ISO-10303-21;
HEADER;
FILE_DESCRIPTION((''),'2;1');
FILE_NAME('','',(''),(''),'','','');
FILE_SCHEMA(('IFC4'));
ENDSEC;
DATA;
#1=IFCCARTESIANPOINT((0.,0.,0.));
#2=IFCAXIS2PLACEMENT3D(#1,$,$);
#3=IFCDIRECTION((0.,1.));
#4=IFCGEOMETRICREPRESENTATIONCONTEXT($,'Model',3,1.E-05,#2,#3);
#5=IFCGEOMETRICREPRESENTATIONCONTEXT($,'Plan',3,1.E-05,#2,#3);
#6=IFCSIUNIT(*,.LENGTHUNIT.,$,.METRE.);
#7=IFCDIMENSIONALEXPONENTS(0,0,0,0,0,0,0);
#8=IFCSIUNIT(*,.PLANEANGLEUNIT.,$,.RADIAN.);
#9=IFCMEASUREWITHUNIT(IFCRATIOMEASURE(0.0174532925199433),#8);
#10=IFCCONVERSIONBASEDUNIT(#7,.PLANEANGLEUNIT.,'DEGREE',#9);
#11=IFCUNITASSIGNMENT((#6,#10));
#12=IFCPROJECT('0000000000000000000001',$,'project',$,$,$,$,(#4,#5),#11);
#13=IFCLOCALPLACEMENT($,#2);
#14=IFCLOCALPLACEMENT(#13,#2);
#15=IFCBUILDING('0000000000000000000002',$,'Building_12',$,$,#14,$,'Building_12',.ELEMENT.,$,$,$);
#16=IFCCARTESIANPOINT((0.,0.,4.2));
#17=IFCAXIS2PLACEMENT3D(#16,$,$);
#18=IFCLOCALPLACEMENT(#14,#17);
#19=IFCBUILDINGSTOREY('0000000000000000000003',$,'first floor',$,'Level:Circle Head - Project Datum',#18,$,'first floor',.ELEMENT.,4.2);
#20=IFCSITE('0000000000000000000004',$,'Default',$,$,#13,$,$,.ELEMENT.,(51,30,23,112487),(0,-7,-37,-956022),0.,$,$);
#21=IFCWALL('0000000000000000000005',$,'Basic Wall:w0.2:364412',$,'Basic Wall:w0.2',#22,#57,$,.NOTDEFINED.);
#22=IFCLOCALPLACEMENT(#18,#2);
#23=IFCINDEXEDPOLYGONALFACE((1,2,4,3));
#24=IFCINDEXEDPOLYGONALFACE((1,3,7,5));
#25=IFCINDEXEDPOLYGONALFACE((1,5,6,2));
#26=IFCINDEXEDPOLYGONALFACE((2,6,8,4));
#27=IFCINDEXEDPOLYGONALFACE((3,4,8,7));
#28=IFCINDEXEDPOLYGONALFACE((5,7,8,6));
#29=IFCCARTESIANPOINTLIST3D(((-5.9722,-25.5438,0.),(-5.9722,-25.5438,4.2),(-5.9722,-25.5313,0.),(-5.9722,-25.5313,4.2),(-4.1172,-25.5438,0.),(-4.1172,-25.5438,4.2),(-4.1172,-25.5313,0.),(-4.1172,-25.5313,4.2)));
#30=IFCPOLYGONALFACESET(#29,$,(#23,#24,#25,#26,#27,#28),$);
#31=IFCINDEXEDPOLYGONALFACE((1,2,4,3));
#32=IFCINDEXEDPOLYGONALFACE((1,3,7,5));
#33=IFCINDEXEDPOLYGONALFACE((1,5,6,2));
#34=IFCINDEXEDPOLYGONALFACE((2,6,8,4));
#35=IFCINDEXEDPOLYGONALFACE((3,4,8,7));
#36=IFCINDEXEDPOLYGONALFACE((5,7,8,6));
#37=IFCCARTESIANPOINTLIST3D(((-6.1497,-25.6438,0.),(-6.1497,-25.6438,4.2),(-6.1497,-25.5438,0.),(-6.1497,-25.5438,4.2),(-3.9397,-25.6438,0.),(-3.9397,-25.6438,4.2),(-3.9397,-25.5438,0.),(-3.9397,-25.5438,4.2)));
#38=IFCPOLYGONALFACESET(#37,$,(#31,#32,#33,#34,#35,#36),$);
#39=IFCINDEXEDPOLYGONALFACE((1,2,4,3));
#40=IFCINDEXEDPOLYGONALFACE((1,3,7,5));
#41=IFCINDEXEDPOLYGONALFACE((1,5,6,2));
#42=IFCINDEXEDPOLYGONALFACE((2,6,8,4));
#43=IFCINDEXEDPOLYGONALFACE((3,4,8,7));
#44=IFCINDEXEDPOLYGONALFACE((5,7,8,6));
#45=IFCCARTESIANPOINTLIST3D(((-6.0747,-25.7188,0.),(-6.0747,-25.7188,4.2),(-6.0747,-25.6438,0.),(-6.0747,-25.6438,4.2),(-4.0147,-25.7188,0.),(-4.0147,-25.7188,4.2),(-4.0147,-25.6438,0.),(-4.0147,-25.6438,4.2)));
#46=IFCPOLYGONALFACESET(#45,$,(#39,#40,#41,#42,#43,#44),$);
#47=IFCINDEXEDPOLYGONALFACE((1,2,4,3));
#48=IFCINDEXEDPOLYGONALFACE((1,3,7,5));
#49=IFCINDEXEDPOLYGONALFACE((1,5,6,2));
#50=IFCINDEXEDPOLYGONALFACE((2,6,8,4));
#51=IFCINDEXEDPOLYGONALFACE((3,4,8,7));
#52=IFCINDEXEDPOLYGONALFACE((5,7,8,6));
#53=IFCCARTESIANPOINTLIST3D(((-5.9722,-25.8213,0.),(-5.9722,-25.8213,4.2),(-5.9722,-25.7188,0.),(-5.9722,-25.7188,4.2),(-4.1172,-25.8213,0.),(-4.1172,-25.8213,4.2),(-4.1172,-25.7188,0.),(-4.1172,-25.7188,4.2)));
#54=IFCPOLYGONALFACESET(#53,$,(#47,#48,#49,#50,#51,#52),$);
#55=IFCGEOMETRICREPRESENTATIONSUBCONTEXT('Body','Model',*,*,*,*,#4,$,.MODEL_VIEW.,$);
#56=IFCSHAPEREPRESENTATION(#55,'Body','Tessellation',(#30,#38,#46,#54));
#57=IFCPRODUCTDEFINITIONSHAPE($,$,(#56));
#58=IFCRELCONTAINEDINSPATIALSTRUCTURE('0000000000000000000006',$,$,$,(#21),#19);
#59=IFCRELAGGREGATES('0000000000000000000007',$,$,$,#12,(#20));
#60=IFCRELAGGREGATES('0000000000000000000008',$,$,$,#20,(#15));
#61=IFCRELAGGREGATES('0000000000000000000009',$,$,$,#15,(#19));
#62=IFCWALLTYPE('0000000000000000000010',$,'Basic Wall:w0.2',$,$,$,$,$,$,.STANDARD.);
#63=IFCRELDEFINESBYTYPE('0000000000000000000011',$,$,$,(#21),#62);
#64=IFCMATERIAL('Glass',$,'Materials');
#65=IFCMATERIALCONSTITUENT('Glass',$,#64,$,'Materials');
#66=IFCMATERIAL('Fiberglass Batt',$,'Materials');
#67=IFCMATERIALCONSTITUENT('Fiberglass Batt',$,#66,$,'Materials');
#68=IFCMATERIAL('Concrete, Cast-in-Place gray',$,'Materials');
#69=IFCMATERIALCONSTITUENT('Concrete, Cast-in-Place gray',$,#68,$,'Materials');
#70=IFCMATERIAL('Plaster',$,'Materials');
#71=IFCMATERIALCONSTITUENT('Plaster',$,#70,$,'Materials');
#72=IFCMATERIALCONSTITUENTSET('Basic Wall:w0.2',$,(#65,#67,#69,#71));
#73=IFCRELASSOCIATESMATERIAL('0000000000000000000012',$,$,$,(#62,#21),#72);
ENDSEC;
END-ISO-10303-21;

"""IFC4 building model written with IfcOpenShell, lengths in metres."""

from ifc_helpers import new_model, entity, si_unit, converted_unit, direction, frame, origin, place, context, subcontext, project, spatial, indexed_curve, outline, extrude, material, constituent, constituent_set, type_object, element, save


model = new_model("IFC4")

# Units and contexts
model_context = context("Model", 3, precision=1e-05, world=origin(), true_north=direction((0.0, 1.0)))
plan_context = context("Plan", 3, precision=1e-05, world=origin(), true_north=direction((0.0, 1.0)))
body_context = subcontext(model_context, "Body", "Model", "MODEL_VIEW")
ifc_project = project(units=[si_unit("LENGTHUNIT", "METRE"), converted_unit("PLANEANGLEUNIT", "DEGREE", entity("IfcRatioMeasure", 0.0174532925199433), si_unit("PLANEANGLEUNIT", "RADIAN"), dimensions=[0, 0, 0, 0, 0, 0, 0])], contexts=[model_context, plan_context])

# Site, building, storey
site_placement = place(None, origin())
site = spatial("IfcSite", under=ifc_project, at=site_placement, Name="Default", CompositionType="ELEMENT", RefLatitude=(51, 30, 23, 112487), RefLongitude=(0, -7, -37, -956022), RefElevation=0.0)
building_placement = place(site_placement, origin())
building = spatial("IfcBuilding", under=site, at=building_placement, Name="Building_12", LongName="Building_12", CompositionType="ELEMENT")
storey_placement = place(building_placement, frame((0.0, 0.0, 4.2)))
storey = spatial("IfcBuildingStorey", under=building, at=storey_placement, Name="first floor", ObjectType="Level:Circle Head - Project Datum", LongName="first floor", CompositionType="ELEMENT", Elevation=4.2)

# Shared definitions
ifc_material_1 = material(Name="Glass", Category="Materials")
ifc_constituent_1 = constituent(ifc_material_1, Name="Glass", Category="Materials")
ifc_material_2 = material(Name="Fiberglass Batt", Category="Materials")
ifc_constituent_2 = constituent(ifc_material_2, Name="Fiberglass Batt", Category="Materials")
ifc_material_3 = material(Name="Concrete, Cast-in-Place gray", Category="Materials")
ifc_constituent_3 = constituent(ifc_material_3, Name="Concrete, Cast-in-Place gray", Category="Materials")
ifc_material_4 = material(Name="Plaster", Category="Materials")
ifc_constituent_4 = constituent(ifc_material_4, Name="Plaster", Category="Materials")
ifc_constituent_set_1 = constituent_set(constituents=[ifc_constituent_1, ifc_constituent_2, ifc_constituent_3, ifc_constituent_4], Name="Basic Wall:w0.2")
wall_type_1 = type_object("IfcWallType", Name="Basic Wall:w0.2", PredefinedType="STANDARD", material=ifc_constituent_set_1)

# Wall
wall_1_placement = place(storey_placement, frame((-4.1172, -25.6763, 0.0), z_axis=(0.0, 0.0, 1.0), x_axis=(-1.0, 0.0, 0.0)))
element("IfcWall", 1, at=wall_1_placement, inside=storey, type_object=wall_type_1, material=ifc_constituent_set_1, Name="Basic Wall:w0.2:364412", ObjectType="Basic Wall:w0.2", PredefinedType="NOTDEFINED", context=body_context, shape_type="SweptSolid", body=[
    extrude(outline(indexed_curve([(-0.0063, -0.9275), (0.0062, -0.9275), (0.0063, 0.9275), (-0.0062, 0.9275), (-0.0063, -0.9275)], self_intersect=False)), frame((0.9275, -0.1387, 0.0), z_axis=(0.0, 0.0, 1.0), x_axis=(0.0, 1.0, 0.0)), (0.0, 0.0, 1.0), 4.2),
    extrude(outline(indexed_curve([(-1.105, -0.05), (1.105, -0.05), (1.105, 0.05), (-1.105, 0.05), (-1.105, -0.05)], self_intersect=False)), frame((0.9275, -0.0825, 0.0)), (0.0, 0.0, 1.0), 4.2),
    extrude(outline(indexed_curve([(-1.03, -0.0375), (1.03, -0.0375), (1.03, 0.0375), (-1.03, 0.0375), (-1.03, -0.0375)], self_intersect=False)), frame((0.9275, 0.005, 0.0)), (0.0, 0.0, 1.0), 4.2),
    extrude(outline(indexed_curve([(-0.0513, -0.9275), (0.0512, -0.9275), (0.0513, 0.9275), (-0.0512, 0.9275), (-0.0513, -0.9275)], self_intersect=False)), frame((0.9275, 0.0938, 0.0), z_axis=(0.0, 0.0, 1.0), x_axis=(0.0, -1.0, 0.0)), (0.0, 0.0, 1.0), 4.2),
])

save(model, "model.ifc")
